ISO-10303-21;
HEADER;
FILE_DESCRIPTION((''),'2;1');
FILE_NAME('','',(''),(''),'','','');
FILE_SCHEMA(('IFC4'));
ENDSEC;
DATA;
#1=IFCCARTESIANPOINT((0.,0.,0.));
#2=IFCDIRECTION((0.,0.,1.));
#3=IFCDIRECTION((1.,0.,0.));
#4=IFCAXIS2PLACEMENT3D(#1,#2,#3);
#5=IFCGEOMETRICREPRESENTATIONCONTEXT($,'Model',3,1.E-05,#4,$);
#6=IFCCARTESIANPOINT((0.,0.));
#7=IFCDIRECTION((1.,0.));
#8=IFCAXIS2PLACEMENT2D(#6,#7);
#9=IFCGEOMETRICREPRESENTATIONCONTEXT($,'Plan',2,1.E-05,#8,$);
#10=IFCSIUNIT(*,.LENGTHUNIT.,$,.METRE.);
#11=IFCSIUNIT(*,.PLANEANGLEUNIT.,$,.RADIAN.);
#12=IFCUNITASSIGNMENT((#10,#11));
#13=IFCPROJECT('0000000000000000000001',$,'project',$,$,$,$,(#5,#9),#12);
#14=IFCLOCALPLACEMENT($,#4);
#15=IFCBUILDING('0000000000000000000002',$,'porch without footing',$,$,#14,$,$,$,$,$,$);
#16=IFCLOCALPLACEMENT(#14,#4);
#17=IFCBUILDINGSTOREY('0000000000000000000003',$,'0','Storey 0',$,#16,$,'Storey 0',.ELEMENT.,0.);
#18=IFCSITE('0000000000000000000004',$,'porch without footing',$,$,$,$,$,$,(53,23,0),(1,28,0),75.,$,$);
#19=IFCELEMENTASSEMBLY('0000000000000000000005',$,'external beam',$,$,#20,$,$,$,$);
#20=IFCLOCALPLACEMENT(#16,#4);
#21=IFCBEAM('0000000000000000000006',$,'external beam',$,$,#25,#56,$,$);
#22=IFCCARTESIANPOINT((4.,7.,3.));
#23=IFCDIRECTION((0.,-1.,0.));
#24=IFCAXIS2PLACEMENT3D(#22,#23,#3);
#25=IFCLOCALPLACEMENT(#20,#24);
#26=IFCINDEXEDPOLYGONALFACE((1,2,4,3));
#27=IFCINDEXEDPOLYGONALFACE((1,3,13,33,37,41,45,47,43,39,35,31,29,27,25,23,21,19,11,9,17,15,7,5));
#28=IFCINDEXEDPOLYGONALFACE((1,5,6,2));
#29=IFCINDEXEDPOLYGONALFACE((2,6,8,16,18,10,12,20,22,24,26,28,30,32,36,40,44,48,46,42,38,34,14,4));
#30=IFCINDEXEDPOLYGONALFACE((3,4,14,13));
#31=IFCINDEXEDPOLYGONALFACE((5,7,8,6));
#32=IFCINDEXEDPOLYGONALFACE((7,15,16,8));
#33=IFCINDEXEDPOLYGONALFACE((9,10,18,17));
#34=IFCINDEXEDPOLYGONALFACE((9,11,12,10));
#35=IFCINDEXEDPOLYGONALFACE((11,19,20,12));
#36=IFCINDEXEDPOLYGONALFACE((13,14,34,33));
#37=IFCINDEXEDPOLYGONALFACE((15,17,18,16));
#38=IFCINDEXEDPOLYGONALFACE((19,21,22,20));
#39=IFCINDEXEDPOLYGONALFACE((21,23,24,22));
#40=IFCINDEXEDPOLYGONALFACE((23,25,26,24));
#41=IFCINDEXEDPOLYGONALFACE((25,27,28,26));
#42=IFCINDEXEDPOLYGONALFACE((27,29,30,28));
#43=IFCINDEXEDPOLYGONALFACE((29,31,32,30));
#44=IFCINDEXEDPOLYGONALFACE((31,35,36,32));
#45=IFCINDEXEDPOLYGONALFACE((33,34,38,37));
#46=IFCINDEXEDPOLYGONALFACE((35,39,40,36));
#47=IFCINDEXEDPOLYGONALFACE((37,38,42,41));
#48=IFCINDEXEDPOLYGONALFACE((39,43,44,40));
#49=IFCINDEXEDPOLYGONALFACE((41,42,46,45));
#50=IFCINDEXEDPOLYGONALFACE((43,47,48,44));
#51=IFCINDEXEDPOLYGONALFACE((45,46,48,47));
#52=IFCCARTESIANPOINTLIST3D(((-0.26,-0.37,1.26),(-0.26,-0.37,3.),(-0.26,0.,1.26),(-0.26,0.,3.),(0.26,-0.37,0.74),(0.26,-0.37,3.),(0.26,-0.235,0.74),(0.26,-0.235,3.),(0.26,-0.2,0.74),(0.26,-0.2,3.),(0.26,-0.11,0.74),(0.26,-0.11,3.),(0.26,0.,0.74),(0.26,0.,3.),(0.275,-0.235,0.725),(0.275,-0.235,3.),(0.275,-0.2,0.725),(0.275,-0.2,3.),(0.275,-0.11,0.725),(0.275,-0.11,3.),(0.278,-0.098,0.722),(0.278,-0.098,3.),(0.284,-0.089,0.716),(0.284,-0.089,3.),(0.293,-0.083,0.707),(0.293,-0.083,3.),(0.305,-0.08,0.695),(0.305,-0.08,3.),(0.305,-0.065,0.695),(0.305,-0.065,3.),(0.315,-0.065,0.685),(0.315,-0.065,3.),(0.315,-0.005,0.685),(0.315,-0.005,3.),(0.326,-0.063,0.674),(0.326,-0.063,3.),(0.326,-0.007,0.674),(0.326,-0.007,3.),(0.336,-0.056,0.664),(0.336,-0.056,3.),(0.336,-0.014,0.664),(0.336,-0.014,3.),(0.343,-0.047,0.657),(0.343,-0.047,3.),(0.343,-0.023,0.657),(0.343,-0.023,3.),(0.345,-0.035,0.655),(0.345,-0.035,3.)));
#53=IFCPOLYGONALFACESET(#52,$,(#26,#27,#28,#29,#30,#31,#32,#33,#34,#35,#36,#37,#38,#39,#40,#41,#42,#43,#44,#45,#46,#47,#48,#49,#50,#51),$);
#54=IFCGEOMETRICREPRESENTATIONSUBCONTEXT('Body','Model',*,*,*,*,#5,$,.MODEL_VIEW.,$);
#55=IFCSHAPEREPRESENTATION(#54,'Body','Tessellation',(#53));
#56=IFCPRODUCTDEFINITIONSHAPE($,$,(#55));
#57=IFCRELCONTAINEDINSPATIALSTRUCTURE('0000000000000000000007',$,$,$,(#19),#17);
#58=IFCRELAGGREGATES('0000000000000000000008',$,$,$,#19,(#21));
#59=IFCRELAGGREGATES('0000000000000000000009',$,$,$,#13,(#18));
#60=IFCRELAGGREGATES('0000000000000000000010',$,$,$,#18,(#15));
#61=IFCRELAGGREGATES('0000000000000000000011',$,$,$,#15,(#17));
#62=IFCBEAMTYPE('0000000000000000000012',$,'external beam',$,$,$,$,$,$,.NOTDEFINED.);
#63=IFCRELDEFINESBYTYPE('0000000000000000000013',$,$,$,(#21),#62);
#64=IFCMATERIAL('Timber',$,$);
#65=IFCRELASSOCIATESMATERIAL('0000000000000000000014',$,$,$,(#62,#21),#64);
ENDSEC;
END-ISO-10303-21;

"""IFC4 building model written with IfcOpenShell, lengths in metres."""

from ifc_helpers import new_model, si_unit, frame, origin_with_axes, origin_2d_with_axis, place, context, subcontext, project, spatial, polyline, outline, extrude, clip, halfspace, material, material_profile, profile_set, profile_usage, type_object, element, aggregate, save


model = new_model("IFC4")

# Units and contexts
model_context = context("Model", 3, precision=1e-05, world=origin_with_axes())
plan_context = context("Plan", 2, precision=1e-05, world=origin_2d_with_axis())
body_context = subcontext(model_context, "Body", "Model", "MODEL_VIEW")
ifc_project = project(units=[si_unit("LENGTHUNIT", "METRE"), si_unit("PLANEANGLEUNIT", "RADIAN")], contexts=[model_context, plan_context])

# Site, building, storey
site = spatial("IfcSite", under=ifc_project, Name="porch without footing", RefLatitude=(53, 23, 0), RefLongitude=(1, 28, 0), RefElevation=75.0)
building_placement = place(None, origin_with_axes())
building = spatial("IfcBuilding", under=site, at=building_placement, Name="porch without footing")
storey_placement = place(building_placement, origin_with_axes())
storey = spatial("IfcBuildingStorey", under=building, at=storey_placement, Name="0", Description="Storey 0", LongName="Storey 0", CompositionType="ELEMENT", Elevation=0.0)

# Element assembly, beam
assembly_1_placement = place(storey_placement, origin_with_axes())
assembly_1 = element("IfcElementAssembly", 1, at=assembly_1_placement, inside=storey, Name="external beam")
ifc_material_1 = material(Name="Timber")
ifc_material_profile_1 = material_profile(ifc_material_1, outline(polyline([(-0.26, 0.0), (-0.26, -0.37), (0.26, -0.37), (0.26, -0.235), (0.275, -0.235), (0.275, -0.2), (0.26, -0.2), (0.26, -0.11), (0.275, -0.11), (0.278, -0.098), (0.284, -0.089), (0.293, -0.083), (0.305, -0.08), (0.305, -0.065), (0.315, -0.065), (0.326, -0.063), (0.336, -0.056), (0.343, -0.047), (0.345, -0.035), (0.343, -0.023), (0.336, -0.014), (0.326, -0.007), (0.315, -0.005), (0.26, 0.0), (-0.26, 0.0)])))
ifc_profile_set_1 = profile_set([ifc_material_profile_1])
ifc_profile_usage_1 = profile_usage(ifc_profile_set_1)
beam_type = type_object("IfcBeamType", Name="external beam", PredefinedType="NOTDEFINED", material=ifc_profile_set_1)
beam_1_placement = place(assembly_1_placement, frame((4.0, 7.0, 3.0), z_axis=(0.0, -1.0, 0.0), x_axis=(1.0, 0.0, 0.0)))
beam_1 = element("IfcBeam", 2, at=beam_1_placement, type_object=beam_type, material=ifc_profile_usage_1, Name="external beam", context=body_context, shape_type="Clipping", body=[
    clip(extrude(outline(polyline([(-0.26, 0.0), (-0.26, -0.37), (0.26, -0.37), (0.26, -0.235), (0.275, -0.235), (0.275, -0.2), (0.26, -0.2), (0.26, -0.11), (0.275, -0.11), (0.278, -0.098), (0.284, -0.089), (0.293, -0.083), (0.305, -0.08), (0.305, -0.065), (0.315, -0.065), (0.326, -0.063), (0.336, -0.056), (0.343, -0.047), (0.345, -0.035), (0.343, -0.023), (0.336, -0.014), (0.326, -0.007), (0.315, -0.005), (0.26, 0.0), (-0.26, 0.0)])), origin_with_axes(), (0.0, 0.0, 1.0), 3.0), halfspace(frame((0.0, -3.0, 1.0), z_axis=(-0.707107, 0.0, -0.707107), x_axis=(0.0, 1.0, 0.0)), False)),
])
aggregate(assembly_1, [beam_1])

save(model, "model.ifc")
